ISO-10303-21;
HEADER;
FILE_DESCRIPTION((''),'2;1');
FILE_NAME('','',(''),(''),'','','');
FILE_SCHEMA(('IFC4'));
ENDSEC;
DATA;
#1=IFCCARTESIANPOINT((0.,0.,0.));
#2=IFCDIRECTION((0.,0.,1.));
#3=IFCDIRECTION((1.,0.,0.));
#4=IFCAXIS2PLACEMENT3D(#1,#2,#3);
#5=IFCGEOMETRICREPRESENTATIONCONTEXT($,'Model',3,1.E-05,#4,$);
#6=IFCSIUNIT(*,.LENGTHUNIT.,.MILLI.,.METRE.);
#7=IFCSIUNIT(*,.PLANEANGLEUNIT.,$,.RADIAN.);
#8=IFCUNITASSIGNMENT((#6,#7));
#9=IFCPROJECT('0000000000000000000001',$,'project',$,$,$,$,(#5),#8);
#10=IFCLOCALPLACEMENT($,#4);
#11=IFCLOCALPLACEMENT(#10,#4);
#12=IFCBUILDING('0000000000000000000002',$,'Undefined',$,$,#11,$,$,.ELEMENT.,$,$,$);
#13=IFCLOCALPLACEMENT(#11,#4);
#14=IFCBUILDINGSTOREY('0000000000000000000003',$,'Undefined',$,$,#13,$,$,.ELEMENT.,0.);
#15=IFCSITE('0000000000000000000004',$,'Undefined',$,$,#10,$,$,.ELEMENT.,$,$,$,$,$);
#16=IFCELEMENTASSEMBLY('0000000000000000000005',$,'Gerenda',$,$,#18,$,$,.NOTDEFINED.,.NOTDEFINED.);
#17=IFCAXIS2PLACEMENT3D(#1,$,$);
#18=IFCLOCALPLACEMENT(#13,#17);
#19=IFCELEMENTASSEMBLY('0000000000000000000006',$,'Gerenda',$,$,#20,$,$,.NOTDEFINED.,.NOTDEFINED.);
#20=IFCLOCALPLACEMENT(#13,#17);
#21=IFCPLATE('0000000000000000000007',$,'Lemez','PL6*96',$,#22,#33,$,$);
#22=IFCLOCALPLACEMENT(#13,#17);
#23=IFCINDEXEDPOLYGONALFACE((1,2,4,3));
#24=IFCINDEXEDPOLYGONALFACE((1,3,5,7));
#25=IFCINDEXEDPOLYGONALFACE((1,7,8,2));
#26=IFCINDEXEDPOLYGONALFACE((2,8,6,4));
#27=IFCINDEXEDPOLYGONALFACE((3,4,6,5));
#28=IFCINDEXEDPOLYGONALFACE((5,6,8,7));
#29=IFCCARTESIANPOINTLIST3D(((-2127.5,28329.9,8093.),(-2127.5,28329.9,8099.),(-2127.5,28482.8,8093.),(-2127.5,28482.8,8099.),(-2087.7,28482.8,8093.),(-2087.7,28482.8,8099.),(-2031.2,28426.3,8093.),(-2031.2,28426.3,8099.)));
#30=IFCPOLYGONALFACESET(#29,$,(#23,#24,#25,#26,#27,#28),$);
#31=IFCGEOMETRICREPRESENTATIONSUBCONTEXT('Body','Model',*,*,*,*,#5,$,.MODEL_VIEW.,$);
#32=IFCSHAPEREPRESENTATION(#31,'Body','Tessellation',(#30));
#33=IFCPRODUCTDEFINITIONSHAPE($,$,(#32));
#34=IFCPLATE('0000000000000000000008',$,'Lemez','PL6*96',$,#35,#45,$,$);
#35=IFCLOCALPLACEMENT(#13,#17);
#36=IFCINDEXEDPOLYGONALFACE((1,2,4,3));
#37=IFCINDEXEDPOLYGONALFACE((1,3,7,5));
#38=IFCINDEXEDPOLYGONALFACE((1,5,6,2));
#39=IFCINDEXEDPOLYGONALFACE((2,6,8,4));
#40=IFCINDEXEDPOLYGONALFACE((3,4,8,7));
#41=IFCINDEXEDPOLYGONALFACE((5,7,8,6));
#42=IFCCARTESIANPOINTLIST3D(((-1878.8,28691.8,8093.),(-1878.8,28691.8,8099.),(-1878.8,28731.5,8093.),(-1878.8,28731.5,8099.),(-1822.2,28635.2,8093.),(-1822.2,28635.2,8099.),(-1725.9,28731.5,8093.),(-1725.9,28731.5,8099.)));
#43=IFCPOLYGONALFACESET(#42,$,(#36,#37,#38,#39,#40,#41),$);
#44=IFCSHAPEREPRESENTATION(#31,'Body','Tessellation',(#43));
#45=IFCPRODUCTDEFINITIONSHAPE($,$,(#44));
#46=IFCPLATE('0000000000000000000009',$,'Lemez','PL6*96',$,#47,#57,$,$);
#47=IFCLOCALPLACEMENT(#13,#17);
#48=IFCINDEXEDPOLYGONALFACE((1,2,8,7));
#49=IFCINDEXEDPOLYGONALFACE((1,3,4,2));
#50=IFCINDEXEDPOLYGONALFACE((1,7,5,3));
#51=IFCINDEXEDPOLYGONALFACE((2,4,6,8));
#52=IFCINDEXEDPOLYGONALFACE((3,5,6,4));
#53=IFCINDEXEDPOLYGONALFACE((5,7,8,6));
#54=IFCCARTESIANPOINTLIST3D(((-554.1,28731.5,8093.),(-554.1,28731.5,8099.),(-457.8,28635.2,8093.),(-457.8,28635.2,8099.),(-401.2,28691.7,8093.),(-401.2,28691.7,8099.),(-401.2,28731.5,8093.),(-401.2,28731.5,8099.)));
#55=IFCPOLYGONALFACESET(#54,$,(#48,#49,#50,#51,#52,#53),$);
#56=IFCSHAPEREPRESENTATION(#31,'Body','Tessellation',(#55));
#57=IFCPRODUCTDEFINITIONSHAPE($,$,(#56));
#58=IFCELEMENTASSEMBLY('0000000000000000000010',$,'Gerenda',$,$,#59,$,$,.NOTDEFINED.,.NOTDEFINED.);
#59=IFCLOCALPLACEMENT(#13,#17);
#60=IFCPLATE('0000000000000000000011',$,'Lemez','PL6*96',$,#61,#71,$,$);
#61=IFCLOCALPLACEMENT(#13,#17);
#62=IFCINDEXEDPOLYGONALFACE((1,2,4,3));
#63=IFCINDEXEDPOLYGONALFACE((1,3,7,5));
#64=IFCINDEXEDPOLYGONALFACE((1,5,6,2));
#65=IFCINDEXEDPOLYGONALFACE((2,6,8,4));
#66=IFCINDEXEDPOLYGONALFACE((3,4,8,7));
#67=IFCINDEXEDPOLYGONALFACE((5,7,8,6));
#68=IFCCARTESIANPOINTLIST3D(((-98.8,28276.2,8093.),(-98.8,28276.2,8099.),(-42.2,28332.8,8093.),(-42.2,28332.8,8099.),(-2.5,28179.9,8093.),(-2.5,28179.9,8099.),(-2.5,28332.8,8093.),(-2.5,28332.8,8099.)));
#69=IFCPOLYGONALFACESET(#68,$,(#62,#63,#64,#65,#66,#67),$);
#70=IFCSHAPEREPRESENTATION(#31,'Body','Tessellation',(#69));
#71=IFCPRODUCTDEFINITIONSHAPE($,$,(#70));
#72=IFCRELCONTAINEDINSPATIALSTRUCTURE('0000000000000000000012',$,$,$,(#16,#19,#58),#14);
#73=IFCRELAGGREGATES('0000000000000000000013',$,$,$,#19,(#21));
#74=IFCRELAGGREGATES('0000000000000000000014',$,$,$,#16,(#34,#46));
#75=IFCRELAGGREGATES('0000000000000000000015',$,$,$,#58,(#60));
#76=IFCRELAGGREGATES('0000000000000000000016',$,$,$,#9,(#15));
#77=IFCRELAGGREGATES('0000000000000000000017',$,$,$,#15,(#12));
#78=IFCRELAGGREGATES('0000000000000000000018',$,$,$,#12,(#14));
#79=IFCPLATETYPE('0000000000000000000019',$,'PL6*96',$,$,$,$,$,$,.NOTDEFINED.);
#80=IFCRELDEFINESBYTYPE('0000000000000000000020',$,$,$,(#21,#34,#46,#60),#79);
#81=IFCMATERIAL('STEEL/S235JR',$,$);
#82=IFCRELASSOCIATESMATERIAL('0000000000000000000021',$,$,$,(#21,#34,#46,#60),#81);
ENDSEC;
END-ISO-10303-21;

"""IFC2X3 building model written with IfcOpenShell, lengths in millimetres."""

from ifc_helpers import new_model, si_unit, frame, origin_with_axes, place, context, subcontext, project, spatial, polyline, outline, extrude, material, type_object, element, aggregate, save


model = new_model("IFC2X3")

# Units and contexts
model_context = context("Model", 3, precision=1e-05, world=origin_with_axes())
body_context = subcontext(model_context, "Body", "Model", "MODEL_VIEW")
ifc_project = project(units=[si_unit("LENGTHUNIT", "METRE", prefix="MILLI"), si_unit("PLANEANGLEUNIT", "RADIAN")], contexts=[model_context])

# Site, building, storey
site_placement = place(None, origin_with_axes())
site = spatial("IfcSite", under=ifc_project, at=site_placement, Name="Undefined", CompositionType="ELEMENT")
building_placement = place(site_placement, origin_with_axes())
building = spatial("IfcBuilding", under=site, at=building_placement, Name="Undefined", CompositionType="ELEMENT")
storey_placement = place(building_placement, origin_with_axes())
storey = spatial("IfcBuildingStorey", under=building, at=storey_placement, Name="Undefined", CompositionType="ELEMENT", Elevation=0.0)

# Element assembly
ifc_material_1 = material(Name="STEEL/S235JR")
assembly_1_placement = place(storey_placement, origin_with_axes())
assembly_1 = element("IfcElementAssembly", 1, at=assembly_1_placement, inside=storey, Name="Gerenda", AssemblyPlace="NOTDEFINED", PredefinedType="NOTDEFINED")

# Element assembly, plate
assembly_2_placement = place(storey_placement, origin_with_axes())
assembly_2 = element("IfcElementAssembly", 2, at=assembly_2_placement, inside=storey, Name="Gerenda", AssemblyPlace="NOTDEFINED", PredefinedType="NOTDEFINED")
plate_type_1 = type_object("IfcPlateType", Name="PL6*96", PredefinedType="NOTDEFINED")
plate_1_placement = place(assembly_2_placement, frame((-2127.5, 28482.8, 8096.0), z_axis=(0.0, 0.0, 1.0), x_axis=(-0.000004, -1.0, 0.0)))
plate_1 = element("IfcPlate", 3, at=plate_1_placement, type_object=plate_type_1, material=ifc_material_1, Name="Lemez", Description="PL6*96", context=body_context, shape_type="SweptSolid", body=[
    extrude(outline(polyline([(0.0, 0.0), (152.9, 0.0), (56.6, 96.3), (0.0, 39.7), (0.0, 0.0)])), frame((0.0, 0.0, -3.0), z_axis=(0.0, 0.0, 1.0), x_axis=(1.0, 0.0, 0.0)), (0.0, 0.0, 1.0), 6.0),
])
aggregate(assembly_2, [plate_1])

# Plates
plate_2_placement = place(assembly_1_placement, frame((-1725.9, 28731.5, 8096.0), z_axis=(0.0, 0.0, 1.0), x_axis=(-1.0, 0.000003, 0.0)))
plate_2 = element("IfcPlate", 4, at=plate_2_placement, type_object=plate_type_1, material=ifc_material_1, Name="Lemez", Description="PL6*96", context=body_context, shape_type="SweptSolid", body=[
    extrude(outline(polyline([(0.0, 0.0), (152.9, 0.0), (152.9, 39.7), (96.3, 96.3), (0.0, 0.0)])), frame((0.0, 0.0, -3.0), z_axis=(0.0, 0.0, 1.0), x_axis=(1.0, 0.0, 0.0)), (0.0, 0.0, 1.0), 6.0),
])
plate_3_placement = place(assembly_1_placement, frame((-401.2, 28731.5, 8096.0), z_axis=(0.0, 0.0, 1.0), x_axis=(-1.0, 0.000003, 0.0)))
plate_3 = element("IfcPlate", 5, at=plate_3_placement, type_object=plate_type_1, material=ifc_material_1, Name="Lemez", Description="PL6*96", context=body_context, shape_type="SweptSolid", body=[
    extrude(outline(polyline([(0.0, 0.0), (152.9, 0.0), (56.6, 96.3), (0.0, 39.7), (0.0, 0.0)])), frame((0.0, 0.0, -3.0), z_axis=(0.0, 0.0, 1.0), x_axis=(1.0, 0.0, 0.0)), (0.0, 0.0, 1.0), 6.0),
])

# Element assembly, plate
assembly_3_placement = place(storey_placement, origin_with_axes())
assembly_3 = element("IfcElementAssembly", 6, at=assembly_3_placement, inside=storey, Name="Gerenda", AssemblyPlace="NOTDEFINED", PredefinedType="NOTDEFINED")
plate_4_placement = place(assembly_3_placement, frame((-2.5, 28179.9, 8096.0), z_axis=(0.0, 0.0, 1.0), x_axis=(0.000003, 1.0, 0.0)))
plate_4 = element("IfcPlate", 7, at=plate_4_placement, type_object=plate_type_1, material=ifc_material_1, Name="Lemez", Description="PL6*96", context=body_context, shape_type="SweptSolid", body=[
    extrude(outline(polyline([(0.0, 0.0), (152.9, 0.0), (152.9, 39.7), (96.3, 96.3), (0.0, 0.0)])), frame((0.0, 0.0, -3.0), z_axis=(0.0, 0.0, 1.0), x_axis=(1.0, 0.0, 0.0)), (0.0, 0.0, 1.0), 6.0),
])

aggregate(assembly_1, [plate_2, plate_3])
aggregate(assembly_3, [plate_4])

save(model, "model.ifc")
